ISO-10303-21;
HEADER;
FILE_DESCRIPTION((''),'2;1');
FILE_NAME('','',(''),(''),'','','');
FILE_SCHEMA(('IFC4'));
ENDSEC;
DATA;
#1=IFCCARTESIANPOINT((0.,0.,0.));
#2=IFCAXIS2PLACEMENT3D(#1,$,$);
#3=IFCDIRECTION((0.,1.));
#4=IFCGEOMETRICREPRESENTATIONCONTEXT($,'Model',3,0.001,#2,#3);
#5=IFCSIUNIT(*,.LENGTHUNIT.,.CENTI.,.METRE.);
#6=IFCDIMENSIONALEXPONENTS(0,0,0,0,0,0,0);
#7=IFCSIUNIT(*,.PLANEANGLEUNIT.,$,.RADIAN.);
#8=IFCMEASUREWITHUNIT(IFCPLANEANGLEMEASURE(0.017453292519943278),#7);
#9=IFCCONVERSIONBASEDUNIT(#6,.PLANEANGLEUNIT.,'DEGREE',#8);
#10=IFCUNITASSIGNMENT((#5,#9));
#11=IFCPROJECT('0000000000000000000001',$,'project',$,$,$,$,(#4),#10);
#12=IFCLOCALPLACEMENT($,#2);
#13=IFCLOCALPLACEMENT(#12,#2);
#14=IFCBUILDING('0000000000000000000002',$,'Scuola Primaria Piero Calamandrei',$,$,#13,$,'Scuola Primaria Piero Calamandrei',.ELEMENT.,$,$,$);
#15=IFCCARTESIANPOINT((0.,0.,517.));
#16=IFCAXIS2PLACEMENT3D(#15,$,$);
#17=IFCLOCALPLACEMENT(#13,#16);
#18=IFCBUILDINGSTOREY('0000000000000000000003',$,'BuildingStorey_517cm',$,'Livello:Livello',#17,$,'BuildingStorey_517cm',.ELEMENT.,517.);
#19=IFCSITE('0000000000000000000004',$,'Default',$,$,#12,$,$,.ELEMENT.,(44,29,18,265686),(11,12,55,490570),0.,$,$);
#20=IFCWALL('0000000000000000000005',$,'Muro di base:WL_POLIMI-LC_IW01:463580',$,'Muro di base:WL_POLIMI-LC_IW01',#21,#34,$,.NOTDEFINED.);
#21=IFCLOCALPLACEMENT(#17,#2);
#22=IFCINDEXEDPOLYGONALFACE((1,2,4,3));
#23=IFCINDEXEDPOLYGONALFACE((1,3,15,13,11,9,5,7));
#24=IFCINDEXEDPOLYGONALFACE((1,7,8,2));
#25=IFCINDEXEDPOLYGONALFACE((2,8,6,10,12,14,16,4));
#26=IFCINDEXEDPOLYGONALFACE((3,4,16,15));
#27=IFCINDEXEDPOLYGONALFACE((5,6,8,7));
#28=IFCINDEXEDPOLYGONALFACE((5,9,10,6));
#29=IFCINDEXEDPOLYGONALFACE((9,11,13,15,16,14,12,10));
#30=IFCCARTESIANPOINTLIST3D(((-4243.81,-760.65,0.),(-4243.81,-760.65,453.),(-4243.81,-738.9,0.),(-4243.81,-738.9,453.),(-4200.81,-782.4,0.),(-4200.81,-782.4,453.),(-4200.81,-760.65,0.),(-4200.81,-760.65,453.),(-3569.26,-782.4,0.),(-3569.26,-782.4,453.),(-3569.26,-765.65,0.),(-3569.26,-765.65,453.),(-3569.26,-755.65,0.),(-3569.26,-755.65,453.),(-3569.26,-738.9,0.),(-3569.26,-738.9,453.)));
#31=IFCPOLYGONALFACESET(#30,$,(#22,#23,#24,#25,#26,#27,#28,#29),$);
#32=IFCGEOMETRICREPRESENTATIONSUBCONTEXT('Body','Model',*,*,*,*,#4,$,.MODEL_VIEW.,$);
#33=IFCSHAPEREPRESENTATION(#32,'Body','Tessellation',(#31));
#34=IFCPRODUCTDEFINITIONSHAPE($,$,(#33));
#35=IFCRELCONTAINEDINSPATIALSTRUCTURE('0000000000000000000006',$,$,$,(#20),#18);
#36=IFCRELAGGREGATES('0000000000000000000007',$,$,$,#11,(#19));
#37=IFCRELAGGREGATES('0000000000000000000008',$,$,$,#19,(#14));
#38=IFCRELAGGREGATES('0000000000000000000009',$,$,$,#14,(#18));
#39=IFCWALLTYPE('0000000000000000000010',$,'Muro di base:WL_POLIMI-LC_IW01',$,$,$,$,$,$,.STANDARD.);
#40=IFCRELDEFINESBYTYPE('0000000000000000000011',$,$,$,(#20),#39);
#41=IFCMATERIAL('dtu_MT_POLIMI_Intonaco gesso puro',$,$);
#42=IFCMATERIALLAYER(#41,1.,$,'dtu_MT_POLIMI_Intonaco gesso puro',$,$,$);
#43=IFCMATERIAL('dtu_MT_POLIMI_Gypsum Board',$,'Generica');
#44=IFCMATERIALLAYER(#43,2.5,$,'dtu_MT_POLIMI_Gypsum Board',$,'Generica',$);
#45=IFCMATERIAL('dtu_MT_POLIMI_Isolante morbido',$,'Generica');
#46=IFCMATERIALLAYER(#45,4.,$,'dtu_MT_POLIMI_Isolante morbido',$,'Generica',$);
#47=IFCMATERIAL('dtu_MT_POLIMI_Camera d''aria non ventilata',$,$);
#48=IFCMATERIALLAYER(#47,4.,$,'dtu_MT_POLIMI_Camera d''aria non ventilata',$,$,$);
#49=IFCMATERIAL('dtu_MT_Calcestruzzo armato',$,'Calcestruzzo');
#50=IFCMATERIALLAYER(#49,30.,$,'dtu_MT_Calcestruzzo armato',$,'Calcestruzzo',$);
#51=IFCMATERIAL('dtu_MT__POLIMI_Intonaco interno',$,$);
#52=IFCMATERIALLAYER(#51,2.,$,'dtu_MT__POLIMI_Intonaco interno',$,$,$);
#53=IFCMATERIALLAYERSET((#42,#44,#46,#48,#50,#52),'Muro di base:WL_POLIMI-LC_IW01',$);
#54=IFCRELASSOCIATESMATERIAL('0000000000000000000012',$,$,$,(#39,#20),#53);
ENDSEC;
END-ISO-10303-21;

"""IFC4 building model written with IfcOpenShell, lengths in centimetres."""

from ifc_helpers import new_model, entity, si_unit, converted_unit, direction, frame, origin, place, context, subcontext, project, spatial, polyline, outline, extrude, material, layer, layer_set, layer_usage, type_object, element, save


model = new_model("IFC4")

# Units and contexts
model_context = context("Model", 3, precision=0.001, world=origin(), true_north=direction((0.0, 1.0)))
body_context = subcontext(model_context, "Body", "Model", "MODEL_VIEW")
ifc_project = project(units=[si_unit("LENGTHUNIT", "METRE", prefix="CENTI"), converted_unit("PLANEANGLEUNIT", "DEGREE", entity("IfcPlaneAngleMeasure", 0.017453292519943278), si_unit("PLANEANGLEUNIT", "RADIAN"), dimensions=[0, 0, 0, 0, 0, 0, 0])], contexts=[model_context])

# Site, building, storey
site_placement = place(None, origin())
site = spatial("IfcSite", under=ifc_project, at=site_placement, Name="Default", CompositionType="ELEMENT", RefLatitude=(44, 29, 18, 265686), RefLongitude=(11, 12, 55, 490570), RefElevation=0.0)
building_placement = place(site_placement, origin())
building = spatial("IfcBuilding", under=site, at=building_placement, Name="Scuola Primaria Piero Calamandrei", LongName="Scuola Primaria Piero Calamandrei", CompositionType="ELEMENT")
storey_placement = place(building_placement, frame((0.0, 0.0, 517.0)))
storey = spatial("IfcBuildingStorey", under=building, at=storey_placement, Name="BuildingStorey_517cm", ObjectType="Livello:Livello", LongName="BuildingStorey_517cm", CompositionType="ELEMENT", Elevation=517.0)

# Shared definitions
ifc_material_1 = material(Name="dtu_MT__POLIMI_Intonaco interno")

# Shared definitions
ifc_material_2 = material(Name="dtu_MT_POLIMI_Isolante morbido", Category="Generica")
ifc_material_3 = material(Name="dtu_MT_POLIMI_Gypsum Board", Category="Generica")

# Shared definitions
ifc_material_4 = material(Name="dtu_MT_POLIMI_Camera d'aria non ventilata")
ifc_material_5 = material(Name="dtu_MT_POLIMI_Intonaco gesso puro")

# Wall
ifc_layer_1 = layer(ifc_material_5, 1.0, Name="dtu_MT_POLIMI_Intonaco gesso puro")
ifc_layer_2 = layer(ifc_material_3, 2.5, Name="dtu_MT_POLIMI_Gypsum Board", Category="Generica")
ifc_layer_3 = layer(ifc_material_2, 4.0, Name="dtu_MT_POLIMI_Isolante morbido", Category="Generica")
ifc_layer_4 = layer(ifc_material_4, 4.0, Name="dtu_MT_POLIMI_Camera d'aria non ventilata")
ifc_material_6 = material(Name="dtu_MT_Calcestruzzo armato", Category="Calcestruzzo")
ifc_layer_5 = layer(ifc_material_6, 30.0, Name="dtu_MT_Calcestruzzo armato", Category="Calcestruzzo")
ifc_layer_6 = layer(ifc_material_1, 2.0, Name="dtu_MT__POLIMI_Intonaco interno")
ifc_layer_set_1 = layer_set([ifc_layer_1, ifc_layer_2, ifc_layer_3, ifc_layer_4, ifc_layer_5, ifc_layer_6], Name="Muro di base:WL_POLIMI-LC_IW01")
ifc_layer_usage_1 = layer_usage(ifc_layer_set_1, "AXIS2", "NEGATIVE", 21.75)
wall_type_1 = type_object("IfcWallType", Name="Muro di base:WL_POLIMI-LC_IW01", PredefinedType="STANDARD", material=ifc_layer_set_1)
wall_1_placement = place(storey_placement, frame((-3569.26, -760.65, 0.0), z_axis=(0.0, 0.0, 1.0), x_axis=(-1.0, 0.0, 0.0)))
element("IfcWall", 1, at=wall_1_placement, inside=storey, type_object=wall_type_1, material=ifc_layer_usage_1, Name="Muro di base:WL_POLIMI-LC_IW01:463580", ObjectType="Muro di base:WL_POLIMI-LC_IW01", PredefinedType="NOTDEFINED", context=body_context, shape_type="SweptSolid", body=[
    extrude(outline(polyline([(-21.75, -348.03), (0.0, -348.03), (0.0, -305.03), (21.75, -305.03), (21.75, 326.53), (5.0, 326.53), (-5.0, 326.53), (-21.75, 326.53), (-21.75, -348.03)])), frame((326.53, 0.0, 0.0), z_axis=(0.0, 0.0, 1.0), x_axis=(0.0, 1.0, 0.0)), (0.0, 0.0, 1.0), 453.0),
])

save(model, "model.ifc")
